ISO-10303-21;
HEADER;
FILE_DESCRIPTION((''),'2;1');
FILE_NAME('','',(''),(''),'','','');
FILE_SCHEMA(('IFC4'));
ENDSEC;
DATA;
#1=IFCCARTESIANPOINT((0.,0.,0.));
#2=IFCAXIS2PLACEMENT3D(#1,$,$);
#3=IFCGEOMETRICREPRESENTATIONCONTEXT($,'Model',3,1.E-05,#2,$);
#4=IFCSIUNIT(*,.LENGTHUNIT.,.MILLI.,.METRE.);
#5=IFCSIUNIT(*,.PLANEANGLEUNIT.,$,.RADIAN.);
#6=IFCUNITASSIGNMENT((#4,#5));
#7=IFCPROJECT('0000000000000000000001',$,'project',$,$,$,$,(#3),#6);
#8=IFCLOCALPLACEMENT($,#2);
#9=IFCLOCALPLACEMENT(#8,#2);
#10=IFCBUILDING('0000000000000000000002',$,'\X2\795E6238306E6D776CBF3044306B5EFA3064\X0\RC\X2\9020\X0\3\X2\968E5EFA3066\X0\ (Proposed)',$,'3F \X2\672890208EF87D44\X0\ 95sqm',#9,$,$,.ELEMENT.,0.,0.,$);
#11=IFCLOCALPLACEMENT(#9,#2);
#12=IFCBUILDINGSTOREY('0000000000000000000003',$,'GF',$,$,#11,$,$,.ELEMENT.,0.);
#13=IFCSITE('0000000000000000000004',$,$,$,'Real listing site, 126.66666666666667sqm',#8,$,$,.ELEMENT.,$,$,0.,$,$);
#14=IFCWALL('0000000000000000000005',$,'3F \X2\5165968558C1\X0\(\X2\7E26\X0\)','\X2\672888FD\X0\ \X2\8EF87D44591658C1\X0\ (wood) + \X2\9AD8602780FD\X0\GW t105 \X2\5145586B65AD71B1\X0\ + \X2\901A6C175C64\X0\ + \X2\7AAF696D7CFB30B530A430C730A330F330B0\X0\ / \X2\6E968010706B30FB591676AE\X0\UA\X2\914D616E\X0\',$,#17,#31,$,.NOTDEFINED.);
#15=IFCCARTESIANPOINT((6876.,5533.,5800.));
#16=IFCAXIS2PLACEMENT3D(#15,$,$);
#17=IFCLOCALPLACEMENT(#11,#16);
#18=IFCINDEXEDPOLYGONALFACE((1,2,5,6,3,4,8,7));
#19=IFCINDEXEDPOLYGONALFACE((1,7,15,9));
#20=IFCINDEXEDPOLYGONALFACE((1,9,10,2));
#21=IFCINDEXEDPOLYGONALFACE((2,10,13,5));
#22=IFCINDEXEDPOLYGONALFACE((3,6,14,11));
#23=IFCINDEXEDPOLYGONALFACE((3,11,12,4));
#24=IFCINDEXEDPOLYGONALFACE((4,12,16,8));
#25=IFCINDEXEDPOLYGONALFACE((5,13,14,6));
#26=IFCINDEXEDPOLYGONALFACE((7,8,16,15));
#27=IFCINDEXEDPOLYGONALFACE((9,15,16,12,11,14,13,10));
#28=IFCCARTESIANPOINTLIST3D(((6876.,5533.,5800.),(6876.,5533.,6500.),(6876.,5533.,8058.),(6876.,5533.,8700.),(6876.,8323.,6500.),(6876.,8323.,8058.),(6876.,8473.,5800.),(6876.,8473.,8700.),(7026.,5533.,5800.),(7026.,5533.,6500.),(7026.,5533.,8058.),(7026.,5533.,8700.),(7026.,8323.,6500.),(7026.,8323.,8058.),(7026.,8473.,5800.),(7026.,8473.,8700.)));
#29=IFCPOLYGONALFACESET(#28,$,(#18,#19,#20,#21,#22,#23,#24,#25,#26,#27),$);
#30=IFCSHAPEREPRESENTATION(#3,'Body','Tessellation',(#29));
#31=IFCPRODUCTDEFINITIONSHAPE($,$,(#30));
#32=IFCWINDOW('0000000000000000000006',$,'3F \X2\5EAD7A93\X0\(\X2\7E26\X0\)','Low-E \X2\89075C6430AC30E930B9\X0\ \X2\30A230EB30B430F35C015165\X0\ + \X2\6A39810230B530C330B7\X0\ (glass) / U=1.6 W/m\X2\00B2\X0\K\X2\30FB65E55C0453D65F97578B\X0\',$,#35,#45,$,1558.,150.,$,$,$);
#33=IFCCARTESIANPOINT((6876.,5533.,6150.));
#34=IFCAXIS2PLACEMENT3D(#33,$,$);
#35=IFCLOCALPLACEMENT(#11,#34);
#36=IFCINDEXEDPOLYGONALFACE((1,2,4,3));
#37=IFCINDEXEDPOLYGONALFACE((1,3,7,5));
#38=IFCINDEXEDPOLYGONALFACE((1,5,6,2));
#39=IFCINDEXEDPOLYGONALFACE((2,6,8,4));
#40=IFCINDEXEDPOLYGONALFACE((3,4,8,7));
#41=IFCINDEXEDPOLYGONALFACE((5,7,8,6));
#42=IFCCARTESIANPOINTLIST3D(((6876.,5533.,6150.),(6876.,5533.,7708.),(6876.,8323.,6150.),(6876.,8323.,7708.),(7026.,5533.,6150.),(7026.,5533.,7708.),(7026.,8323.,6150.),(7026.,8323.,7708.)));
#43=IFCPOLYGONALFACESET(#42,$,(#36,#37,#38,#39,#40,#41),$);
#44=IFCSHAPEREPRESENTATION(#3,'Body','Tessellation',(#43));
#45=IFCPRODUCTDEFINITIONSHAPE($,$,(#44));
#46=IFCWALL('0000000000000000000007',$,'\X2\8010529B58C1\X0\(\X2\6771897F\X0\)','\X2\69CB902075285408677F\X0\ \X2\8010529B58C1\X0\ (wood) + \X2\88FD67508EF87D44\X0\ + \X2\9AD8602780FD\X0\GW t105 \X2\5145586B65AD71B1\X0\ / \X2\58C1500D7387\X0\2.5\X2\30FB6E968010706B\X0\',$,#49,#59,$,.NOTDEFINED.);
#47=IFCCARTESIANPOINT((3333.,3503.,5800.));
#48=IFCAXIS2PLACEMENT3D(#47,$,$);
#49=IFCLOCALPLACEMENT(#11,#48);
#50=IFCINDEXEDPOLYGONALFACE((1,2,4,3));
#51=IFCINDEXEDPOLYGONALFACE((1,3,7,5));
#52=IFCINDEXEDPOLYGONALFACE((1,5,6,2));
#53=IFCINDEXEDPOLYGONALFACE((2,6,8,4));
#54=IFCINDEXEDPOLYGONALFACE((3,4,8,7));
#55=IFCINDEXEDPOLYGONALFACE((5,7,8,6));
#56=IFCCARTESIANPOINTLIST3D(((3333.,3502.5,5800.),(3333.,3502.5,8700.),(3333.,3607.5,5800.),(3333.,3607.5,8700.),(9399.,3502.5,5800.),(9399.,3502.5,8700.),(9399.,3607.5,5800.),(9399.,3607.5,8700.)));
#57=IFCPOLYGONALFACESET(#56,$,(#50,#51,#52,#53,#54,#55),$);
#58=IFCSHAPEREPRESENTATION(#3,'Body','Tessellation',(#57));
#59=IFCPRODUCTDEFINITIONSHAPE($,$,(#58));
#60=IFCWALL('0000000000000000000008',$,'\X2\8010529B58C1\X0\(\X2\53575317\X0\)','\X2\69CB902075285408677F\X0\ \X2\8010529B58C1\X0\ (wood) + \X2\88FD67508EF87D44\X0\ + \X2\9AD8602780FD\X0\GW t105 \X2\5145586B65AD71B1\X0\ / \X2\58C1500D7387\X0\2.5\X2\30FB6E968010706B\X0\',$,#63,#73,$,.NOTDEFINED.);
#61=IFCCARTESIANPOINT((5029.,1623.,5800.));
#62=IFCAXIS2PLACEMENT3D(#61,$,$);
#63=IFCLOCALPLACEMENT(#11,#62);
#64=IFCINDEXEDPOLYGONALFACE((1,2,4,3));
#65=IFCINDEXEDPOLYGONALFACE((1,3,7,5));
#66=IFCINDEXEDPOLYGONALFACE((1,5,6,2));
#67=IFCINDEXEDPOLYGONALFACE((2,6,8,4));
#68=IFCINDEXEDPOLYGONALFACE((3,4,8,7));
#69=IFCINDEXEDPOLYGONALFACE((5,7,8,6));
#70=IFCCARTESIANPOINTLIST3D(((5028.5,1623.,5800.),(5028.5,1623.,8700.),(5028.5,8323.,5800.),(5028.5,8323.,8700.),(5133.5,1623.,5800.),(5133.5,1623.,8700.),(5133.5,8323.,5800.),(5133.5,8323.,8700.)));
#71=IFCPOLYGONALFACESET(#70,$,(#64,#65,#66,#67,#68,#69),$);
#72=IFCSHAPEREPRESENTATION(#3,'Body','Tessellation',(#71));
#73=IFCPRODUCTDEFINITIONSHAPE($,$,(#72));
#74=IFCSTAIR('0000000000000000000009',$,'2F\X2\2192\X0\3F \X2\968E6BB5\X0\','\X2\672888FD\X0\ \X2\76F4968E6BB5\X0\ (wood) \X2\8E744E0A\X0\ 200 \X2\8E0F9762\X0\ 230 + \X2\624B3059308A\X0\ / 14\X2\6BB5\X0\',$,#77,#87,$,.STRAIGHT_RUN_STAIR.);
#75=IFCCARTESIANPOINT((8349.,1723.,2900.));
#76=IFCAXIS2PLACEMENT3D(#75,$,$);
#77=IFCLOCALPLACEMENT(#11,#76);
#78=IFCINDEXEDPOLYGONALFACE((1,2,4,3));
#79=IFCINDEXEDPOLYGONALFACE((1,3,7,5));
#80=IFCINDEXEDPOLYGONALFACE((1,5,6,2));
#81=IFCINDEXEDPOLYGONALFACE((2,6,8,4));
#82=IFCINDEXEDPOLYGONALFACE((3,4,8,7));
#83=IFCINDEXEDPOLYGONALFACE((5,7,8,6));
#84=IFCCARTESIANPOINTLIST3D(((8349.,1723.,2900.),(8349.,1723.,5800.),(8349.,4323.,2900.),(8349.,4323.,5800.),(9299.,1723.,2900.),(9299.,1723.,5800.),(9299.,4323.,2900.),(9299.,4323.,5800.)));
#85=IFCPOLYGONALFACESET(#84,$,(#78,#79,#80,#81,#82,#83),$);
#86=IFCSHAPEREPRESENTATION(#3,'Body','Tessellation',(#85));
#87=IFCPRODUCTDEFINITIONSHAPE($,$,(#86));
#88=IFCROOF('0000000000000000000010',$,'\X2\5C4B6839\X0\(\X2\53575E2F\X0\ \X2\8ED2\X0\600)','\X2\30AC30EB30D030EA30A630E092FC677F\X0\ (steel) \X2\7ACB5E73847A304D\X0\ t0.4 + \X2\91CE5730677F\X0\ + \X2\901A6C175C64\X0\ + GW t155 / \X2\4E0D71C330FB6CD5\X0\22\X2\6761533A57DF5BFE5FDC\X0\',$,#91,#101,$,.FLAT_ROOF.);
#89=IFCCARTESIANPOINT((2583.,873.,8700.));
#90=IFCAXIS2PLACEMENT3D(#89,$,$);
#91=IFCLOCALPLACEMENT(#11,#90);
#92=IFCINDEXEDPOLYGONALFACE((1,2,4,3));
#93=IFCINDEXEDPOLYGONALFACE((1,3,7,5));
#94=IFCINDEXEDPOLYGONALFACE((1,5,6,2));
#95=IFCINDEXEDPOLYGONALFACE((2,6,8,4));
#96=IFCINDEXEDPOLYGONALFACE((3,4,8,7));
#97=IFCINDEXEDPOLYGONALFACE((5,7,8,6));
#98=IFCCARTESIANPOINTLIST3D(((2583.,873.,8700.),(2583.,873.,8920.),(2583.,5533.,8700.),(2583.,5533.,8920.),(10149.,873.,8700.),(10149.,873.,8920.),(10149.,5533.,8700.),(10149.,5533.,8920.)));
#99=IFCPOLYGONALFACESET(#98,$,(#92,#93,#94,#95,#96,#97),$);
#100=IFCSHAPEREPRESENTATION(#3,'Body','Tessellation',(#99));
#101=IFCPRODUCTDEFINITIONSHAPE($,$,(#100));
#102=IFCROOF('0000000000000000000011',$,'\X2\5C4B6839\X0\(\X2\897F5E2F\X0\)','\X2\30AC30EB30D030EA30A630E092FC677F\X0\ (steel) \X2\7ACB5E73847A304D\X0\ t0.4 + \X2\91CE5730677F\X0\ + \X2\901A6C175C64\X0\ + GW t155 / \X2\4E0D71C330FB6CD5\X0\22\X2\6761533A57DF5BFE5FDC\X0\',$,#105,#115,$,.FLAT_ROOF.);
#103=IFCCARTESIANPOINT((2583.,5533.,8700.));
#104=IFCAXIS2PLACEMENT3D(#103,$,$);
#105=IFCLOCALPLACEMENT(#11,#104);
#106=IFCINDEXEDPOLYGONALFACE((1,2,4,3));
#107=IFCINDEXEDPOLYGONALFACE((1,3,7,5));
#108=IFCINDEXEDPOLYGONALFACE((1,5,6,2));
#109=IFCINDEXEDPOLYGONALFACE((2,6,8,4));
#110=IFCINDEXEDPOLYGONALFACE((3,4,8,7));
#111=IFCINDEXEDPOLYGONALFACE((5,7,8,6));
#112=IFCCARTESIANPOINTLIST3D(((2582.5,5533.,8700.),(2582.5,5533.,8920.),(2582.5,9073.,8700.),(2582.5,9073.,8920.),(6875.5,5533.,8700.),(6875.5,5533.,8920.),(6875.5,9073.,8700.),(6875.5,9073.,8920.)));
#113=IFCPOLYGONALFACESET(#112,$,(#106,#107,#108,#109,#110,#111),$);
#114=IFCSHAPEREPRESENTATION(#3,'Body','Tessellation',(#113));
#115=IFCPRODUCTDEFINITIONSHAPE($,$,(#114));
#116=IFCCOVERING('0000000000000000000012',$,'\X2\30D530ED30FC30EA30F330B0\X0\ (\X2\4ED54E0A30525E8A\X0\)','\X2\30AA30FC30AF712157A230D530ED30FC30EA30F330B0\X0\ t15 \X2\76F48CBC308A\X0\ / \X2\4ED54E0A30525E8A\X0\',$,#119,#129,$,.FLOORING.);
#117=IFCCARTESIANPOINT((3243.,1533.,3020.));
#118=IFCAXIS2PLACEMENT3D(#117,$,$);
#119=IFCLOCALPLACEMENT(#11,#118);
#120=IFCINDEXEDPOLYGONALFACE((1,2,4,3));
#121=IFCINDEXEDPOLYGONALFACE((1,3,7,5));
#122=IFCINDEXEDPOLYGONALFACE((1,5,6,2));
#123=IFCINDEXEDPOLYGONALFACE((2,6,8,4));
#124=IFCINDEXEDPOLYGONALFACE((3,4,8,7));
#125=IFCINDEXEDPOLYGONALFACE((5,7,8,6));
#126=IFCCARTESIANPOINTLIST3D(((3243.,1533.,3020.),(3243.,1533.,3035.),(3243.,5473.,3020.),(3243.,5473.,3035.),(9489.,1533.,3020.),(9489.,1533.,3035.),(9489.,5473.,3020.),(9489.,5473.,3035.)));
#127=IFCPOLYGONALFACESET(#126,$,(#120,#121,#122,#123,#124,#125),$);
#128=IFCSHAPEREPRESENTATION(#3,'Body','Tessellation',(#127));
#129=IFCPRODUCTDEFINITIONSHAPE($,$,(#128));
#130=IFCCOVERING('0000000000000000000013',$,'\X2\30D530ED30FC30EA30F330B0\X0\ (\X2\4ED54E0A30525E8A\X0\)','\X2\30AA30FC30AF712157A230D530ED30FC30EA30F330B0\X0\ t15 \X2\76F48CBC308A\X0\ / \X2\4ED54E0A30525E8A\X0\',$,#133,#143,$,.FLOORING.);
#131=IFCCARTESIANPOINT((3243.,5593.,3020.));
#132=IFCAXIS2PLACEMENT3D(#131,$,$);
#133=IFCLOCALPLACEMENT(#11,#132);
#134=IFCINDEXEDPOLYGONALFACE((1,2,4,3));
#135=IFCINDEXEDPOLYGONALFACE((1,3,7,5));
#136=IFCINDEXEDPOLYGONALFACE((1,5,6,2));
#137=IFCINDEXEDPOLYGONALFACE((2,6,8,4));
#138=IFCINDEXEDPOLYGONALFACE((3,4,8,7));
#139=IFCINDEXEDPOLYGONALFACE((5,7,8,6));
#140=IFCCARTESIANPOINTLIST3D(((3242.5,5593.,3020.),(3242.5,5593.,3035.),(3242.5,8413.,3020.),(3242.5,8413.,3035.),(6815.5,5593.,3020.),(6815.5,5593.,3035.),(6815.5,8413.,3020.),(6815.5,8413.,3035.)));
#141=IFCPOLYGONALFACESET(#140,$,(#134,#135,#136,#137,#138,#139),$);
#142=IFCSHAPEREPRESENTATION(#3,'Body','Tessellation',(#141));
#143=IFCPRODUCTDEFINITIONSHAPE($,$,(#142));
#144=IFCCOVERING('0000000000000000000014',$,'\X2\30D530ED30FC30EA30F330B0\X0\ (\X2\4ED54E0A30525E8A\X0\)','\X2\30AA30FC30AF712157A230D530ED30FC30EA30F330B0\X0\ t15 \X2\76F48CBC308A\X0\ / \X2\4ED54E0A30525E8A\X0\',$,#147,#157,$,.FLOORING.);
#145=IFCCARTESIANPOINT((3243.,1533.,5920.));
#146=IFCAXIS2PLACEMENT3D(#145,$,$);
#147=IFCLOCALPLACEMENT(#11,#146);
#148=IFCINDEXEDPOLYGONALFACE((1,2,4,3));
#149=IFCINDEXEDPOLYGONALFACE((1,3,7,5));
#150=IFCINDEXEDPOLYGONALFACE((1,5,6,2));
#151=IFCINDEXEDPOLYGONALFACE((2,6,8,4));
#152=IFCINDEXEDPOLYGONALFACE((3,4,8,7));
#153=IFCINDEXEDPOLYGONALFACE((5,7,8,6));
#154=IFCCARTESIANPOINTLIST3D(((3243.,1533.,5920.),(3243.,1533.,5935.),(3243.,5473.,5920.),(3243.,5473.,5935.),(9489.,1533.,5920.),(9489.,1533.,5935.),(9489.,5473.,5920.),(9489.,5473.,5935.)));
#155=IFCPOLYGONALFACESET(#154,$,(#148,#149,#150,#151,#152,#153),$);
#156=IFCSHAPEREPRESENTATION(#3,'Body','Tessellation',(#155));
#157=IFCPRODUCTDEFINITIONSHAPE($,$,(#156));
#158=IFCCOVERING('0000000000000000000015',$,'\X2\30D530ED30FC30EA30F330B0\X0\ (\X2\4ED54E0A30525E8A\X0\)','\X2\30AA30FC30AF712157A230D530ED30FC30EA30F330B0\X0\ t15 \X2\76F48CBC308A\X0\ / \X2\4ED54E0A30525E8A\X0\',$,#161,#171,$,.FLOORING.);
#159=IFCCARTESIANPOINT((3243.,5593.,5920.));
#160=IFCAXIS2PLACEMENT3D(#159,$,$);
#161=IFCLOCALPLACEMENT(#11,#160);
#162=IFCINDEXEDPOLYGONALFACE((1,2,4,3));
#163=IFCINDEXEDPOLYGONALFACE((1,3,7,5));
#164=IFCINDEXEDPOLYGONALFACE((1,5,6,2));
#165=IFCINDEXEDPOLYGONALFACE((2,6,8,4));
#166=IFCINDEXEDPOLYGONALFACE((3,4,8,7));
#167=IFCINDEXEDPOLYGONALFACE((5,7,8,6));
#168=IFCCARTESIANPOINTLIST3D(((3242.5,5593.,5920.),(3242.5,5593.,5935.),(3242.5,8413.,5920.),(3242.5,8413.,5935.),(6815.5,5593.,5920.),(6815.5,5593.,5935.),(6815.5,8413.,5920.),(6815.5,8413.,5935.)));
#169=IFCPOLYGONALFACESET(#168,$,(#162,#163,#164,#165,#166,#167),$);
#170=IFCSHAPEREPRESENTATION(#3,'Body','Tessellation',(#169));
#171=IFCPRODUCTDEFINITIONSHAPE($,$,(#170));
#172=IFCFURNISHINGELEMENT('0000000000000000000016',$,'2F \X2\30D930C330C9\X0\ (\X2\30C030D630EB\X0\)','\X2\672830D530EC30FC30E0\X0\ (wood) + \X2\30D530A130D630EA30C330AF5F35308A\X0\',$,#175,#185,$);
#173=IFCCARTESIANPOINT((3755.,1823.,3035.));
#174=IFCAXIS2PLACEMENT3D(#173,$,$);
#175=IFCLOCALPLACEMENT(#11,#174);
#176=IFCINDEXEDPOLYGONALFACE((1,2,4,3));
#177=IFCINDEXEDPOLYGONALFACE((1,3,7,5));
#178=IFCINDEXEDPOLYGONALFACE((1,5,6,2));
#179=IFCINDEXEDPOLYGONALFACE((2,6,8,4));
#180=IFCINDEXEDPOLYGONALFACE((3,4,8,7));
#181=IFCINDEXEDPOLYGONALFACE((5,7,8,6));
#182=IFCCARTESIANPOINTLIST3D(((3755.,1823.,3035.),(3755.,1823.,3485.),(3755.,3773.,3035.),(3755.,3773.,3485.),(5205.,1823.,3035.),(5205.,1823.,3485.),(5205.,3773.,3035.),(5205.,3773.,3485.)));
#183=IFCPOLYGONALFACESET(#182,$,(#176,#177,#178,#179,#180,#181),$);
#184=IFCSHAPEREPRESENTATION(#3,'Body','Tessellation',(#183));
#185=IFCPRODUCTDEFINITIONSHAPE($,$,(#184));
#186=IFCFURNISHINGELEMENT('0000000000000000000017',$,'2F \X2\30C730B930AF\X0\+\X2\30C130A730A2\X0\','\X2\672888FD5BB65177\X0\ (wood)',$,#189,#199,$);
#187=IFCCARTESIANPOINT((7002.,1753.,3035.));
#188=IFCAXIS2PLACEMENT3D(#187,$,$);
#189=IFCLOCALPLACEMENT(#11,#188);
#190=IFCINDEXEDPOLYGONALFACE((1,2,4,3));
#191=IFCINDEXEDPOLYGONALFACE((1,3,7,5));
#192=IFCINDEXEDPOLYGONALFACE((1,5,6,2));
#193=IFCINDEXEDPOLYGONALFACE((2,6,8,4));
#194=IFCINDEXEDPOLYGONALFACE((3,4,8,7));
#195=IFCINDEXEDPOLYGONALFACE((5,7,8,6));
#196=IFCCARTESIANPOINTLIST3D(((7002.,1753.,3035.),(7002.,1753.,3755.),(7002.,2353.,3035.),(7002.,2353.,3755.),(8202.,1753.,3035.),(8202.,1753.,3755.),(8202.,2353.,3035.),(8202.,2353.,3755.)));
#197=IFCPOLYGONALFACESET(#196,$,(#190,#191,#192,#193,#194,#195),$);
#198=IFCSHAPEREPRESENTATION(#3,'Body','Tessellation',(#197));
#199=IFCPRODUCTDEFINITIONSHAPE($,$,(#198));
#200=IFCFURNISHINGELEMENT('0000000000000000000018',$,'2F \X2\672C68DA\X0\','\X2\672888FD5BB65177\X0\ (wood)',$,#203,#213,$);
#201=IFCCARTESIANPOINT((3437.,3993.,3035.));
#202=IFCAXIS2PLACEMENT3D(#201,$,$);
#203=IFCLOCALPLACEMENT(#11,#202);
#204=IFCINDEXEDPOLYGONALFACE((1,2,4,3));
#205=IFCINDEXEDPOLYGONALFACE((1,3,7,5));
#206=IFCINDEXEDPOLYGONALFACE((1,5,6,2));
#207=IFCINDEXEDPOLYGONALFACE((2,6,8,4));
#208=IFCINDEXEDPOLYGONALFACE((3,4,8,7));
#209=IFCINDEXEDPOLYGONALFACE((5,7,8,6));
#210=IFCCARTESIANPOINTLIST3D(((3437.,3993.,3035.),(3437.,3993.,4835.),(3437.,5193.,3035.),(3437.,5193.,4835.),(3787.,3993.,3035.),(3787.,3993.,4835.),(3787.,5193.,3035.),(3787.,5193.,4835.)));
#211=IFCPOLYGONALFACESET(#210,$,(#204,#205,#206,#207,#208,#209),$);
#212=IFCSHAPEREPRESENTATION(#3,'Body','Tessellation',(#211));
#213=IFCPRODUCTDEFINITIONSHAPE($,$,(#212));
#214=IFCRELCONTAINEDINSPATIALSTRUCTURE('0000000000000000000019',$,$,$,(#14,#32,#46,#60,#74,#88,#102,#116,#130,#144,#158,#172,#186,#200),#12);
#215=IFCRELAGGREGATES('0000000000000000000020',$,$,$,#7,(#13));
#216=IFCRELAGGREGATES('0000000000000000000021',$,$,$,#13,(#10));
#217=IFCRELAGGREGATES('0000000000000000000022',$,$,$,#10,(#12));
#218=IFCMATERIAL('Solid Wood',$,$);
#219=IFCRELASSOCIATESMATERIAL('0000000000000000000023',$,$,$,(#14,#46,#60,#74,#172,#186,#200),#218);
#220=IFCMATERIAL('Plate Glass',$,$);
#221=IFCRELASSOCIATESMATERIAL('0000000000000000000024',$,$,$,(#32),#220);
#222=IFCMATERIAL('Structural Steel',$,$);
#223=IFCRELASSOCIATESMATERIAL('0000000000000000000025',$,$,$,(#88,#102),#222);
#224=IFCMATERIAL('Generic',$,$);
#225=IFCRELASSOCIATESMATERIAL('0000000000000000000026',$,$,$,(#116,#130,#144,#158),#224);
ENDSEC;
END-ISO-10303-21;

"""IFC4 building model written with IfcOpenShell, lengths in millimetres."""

from ifc_helpers import new_model, si_unit, frame, frame_2d, origin, place, context, project, spatial, rectangle, extrude, material, element, fill, save


model = new_model("IFC4")

# Units and contexts
model_context = context("Model", 3, precision=1e-05, world=origin())
ifc_project = project(units=[si_unit("LENGTHUNIT", "METRE", prefix="MILLI"), si_unit("PLANEANGLEUNIT", "RADIAN")], contexts=[model_context])

# Site, building, storey
site_placement = place(None, origin())
site = spatial("IfcSite", under=ifc_project, at=site_placement, ObjectType="Real listing site, 126.66666666666667sqm", CompositionType="ELEMENT", RefElevation=0.0)
building_placement = place(site_placement, origin())
building = spatial("IfcBuilding", under=site, at=building_placement, Name="神戸の海沿いに建つRC造3階建て (Proposed)", ObjectType="3F 木造軸組 95sqm", CompositionType="ELEMENT", ElevationOfRefHeight=0.0, ElevationOfTerrain=0.0)
storey_placement = place(building_placement, origin())
storey = spatial("IfcBuildingStorey", under=building, at=storey_placement, Name="GF", CompositionType="ELEMENT", Elevation=0.0)

# Shared definitions
ifc_material_1 = material(Name="Solid Wood")

# Shared definitions
ifc_material_2 = material(Name="Plate Glass")

# Wall, opening, window
wall_1_placement = place(storey_placement, frame((6876.0, 5533.0, 5800.0)))
wall_1 = element("IfcWall", 1, at=wall_1_placement, inside=storey, material=ifc_material_1, Name="3F 入隅壁(縦)", Description="木製 軸組外壁 (wood) + 高性能GW t105 充填断熱 + 通気層 + 窯業系サイディング / 準耐火・外皮UA配慮", PredefinedType="NOTDEFINED", context=model_context, shape_type="SweptSolid", body=[
    extrude(rectangle(XDim=150.0, YDim=2940.0, at=frame_2d((75.0, 1470.0))), frame((6876.0, 5533.0, 5800.0)), (0.0, 0.0, 1.0), 2900.0),
])
opening_1_placement = place(storey_placement, frame((6876.0, 5533.0, 6150.0)))
opening_1 = element("IfcOpeningElement", 2, at=opening_1_placement, cuts=wall_1, PredefinedType="NOTDEFINED", context=model_context, shape_type="SweptSolid", body=[
    extrude(rectangle(XDim=150.0, YDim=2790.0, at=frame_2d((75.0, 1395.0))), frame((6876.0, 5533.0, 6150.0)), (0.0, 0.0, 1.0), 1558.0),
])
window_1_placement = place(storey_placement, frame((6876.0, 5533.0, 6150.0)))
window_1 = element("IfcWindow", 3, at=window_1_placement, inside=storey, material=ifc_material_2, Name="3F 庭窓(縦)", Description="Low-E 複層ガラス アルゴン封入 + 樹脂サッシ (glass) / U=1.6 W/m²K・日射取得型", OverallHeight=1558.0, OverallWidth=150.0, context=model_context, shape_type="SweptSolid", body=[
    extrude(rectangle(XDim=150.0, YDim=2790.0, at=frame_2d((75.0, 1395.0))), frame((6876.0, 5533.0, 6150.0)), (0.0, 0.0, 1.0), 1558.0),
])
fill(opening_1, window_1)

# Walls
wall_2_placement = place(storey_placement, frame((3333.0, 3503.0, 5800.0)))
element("IfcWall", 4, at=wall_2_placement, inside=storey, material=ifc_material_1, Name="耐力壁(東西)", Description="構造用合板 耐力壁 (wood) + 製材軸組 + 高性能GW t105 充填断熱 / 壁倍率2.5・準耐火", PredefinedType="NOTDEFINED", context=model_context, shape_type="SweptSolid", body=[
    extrude(rectangle(XDim=6066.0, YDim=105.0, at=frame_2d((3033.0, 52.0))), frame((3333.0, 3503.0, 5800.0)), (0.0, 0.0, 1.0), 2900.0),
])
wall_3_placement = place(storey_placement, frame((5029.0, 1623.0, 5800.0)))
element("IfcWall", 5, at=wall_3_placement, inside=storey, material=ifc_material_1, Name="耐力壁(南北)", Description="構造用合板 耐力壁 (wood) + 製材軸組 + 高性能GW t105 充填断熱 / 壁倍率2.5・準耐火", PredefinedType="NOTDEFINED", context=model_context, shape_type="SweptSolid", body=[
    extrude(rectangle(XDim=105.0, YDim=6700.0, at=frame_2d((52.0, 3350.0))), frame((5029.0, 1623.0, 5800.0)), (0.0, 0.0, 1.0), 2900.0),
])

# Stair
stair_placement = place(storey_placement, frame((8349.0, 1723.0, 2900.0)))
element("IfcStair", 6, at=stair_placement, inside=storey, material=ifc_material_1, Name="2F→3F 階段", Description="木製 直階段 (wood) 蹴上 200 踏面 230 + 手すり / 14段", PredefinedType="STRAIGHT_RUN_STAIR", context=model_context, shape_type="SweptSolid", body=[
    extrude(rectangle(XDim=950.0, YDim=2600.0, at=frame_2d((475.0, 1300.0))), frame((8349.0, 1723.0, 2900.0)), (0.0, 0.0, 1.0), 2900.0),
])

# Roofs
ifc_material_3 = material(Name="Structural Steel")
roof_1_placement = place(storey_placement, frame((2583.0, 873.0, 8700.0)))
element("IfcRoof", 7, at=roof_1_placement, inside=storey, material=ifc_material_3, Name="屋根(南帯 軒600)", Description="ガルバリウム鋼板 (steel) 立平葺き t0.4 + 野地板 + 通気層 + GW t155 / 不燃・法22条区域対応", PredefinedType="FLAT_ROOF", context=model_context, shape_type="SweptSolid", body=[
    extrude(rectangle(XDim=7566.0, YDim=4660.0, at=frame_2d((3783.0, 2330.0))), frame((2583.0, 873.0, 8700.0)), (0.0, 0.0, 1.0), 220.0),
])
roof_2_placement = place(storey_placement, frame((2583.0, 5533.0, 8700.0)))
element("IfcRoof", 8, at=roof_2_placement, inside=storey, material=ifc_material_3, Name="屋根(西帯)", Description="ガルバリウム鋼板 (steel) 立平葺き t0.4 + 野地板 + 通気層 + GW t155 / 不燃・法22条区域対応", PredefinedType="FLAT_ROOF", context=model_context, shape_type="SweptSolid", body=[
    extrude(rectangle(XDim=4293.0, YDim=3540.0, at=frame_2d((2146.0, 1770.0))), frame((2583.0, 5533.0, 8700.0)), (0.0, 0.0, 1.0), 220.0),
])

# Coverings
ifc_material_4 = material(Name="Generic")
covering_1_placement = place(storey_placement, frame((3243.0, 1533.0, 3020.0)))
element("IfcCovering", 9, at=covering_1_placement, inside=storey, material=ifc_material_4, Name="フローリング (仕上げ床)", Description="オーク無垢フローリング t15 直貼り / 仕上げ床", PredefinedType="FLOORING", context=model_context, shape_type="SweptSolid", body=[
    extrude(rectangle(XDim=6246.0, YDim=3940.0, at=frame_2d((3123.0, 1970.0))), frame((3243.0, 1533.0, 3020.0)), (0.0, 0.0, 1.0), 15.0),
])
covering_2_placement = place(storey_placement, frame((3243.0, 5593.0, 3020.0)))
element("IfcCovering", 10, at=covering_2_placement, inside=storey, material=ifc_material_4, Name="フローリング (仕上げ床)", Description="オーク無垢フローリング t15 直貼り / 仕上げ床", PredefinedType="FLOORING", context=model_context, shape_type="SweptSolid", body=[
    extrude(rectangle(XDim=3573.0, YDim=2820.0, at=frame_2d((1786.0, 1410.0))), frame((3243.0, 5593.0, 3020.0)), (0.0, 0.0, 1.0), 15.0),
])
covering_3_placement = place(storey_placement, frame((3243.0, 1533.0, 5920.0)))
element("IfcCovering", 11, at=covering_3_placement, inside=storey, material=ifc_material_4, Name="フローリング (仕上げ床)", Description="オーク無垢フローリング t15 直貼り / 仕上げ床", PredefinedType="FLOORING", context=model_context, shape_type="SweptSolid", body=[
    extrude(rectangle(XDim=6246.0, YDim=3940.0, at=frame_2d((3123.0, 1970.0))), frame((3243.0, 1533.0, 5920.0)), (0.0, 0.0, 1.0), 15.0),
])
covering_4_placement = place(storey_placement, frame((3243.0, 5593.0, 5920.0)))
element("IfcCovering", 12, at=covering_4_placement, inside=storey, material=ifc_material_4, Name="フローリング (仕上げ床)", Description="オーク無垢フローリング t15 直貼り / 仕上げ床", PredefinedType="FLOORING", context=model_context, shape_type="SweptSolid", body=[
    extrude(rectangle(XDim=3573.0, YDim=2820.0, at=frame_2d((1786.0, 1410.0))), frame((3243.0, 5593.0, 5920.0)), (0.0, 0.0, 1.0), 15.0),
])

# Furnishing elements
furnishing_1_placement = place(storey_placement, frame((3755.0, 1823.0, 3035.0)))
element("IfcFurnishingElement", 13, at=furnishing_1_placement, inside=storey, material=ifc_material_1, Name="2F ベッド (ダブル)", Description="木フレーム (wood) + ファブリック張り", context=model_context, shape_type="SweptSolid", body=[
    extrude(rectangle(XDim=1450.0, YDim=1950.0, at=frame_2d((725.0, 975.0))), frame((3755.0, 1823.0, 3035.0)), (0.0, 0.0, 1.0), 450.0),
])
furnishing_2_placement = place(storey_placement, frame((7002.0, 1753.0, 3035.0)))
element("IfcFurnishingElement", 14, at=furnishing_2_placement, inside=storey, material=ifc_material_1, Name="2F デスク+チェア", Description="木製家具 (wood)", context=model_context, shape_type="SweptSolid", body=[
    extrude(rectangle(XDim=1200.0, YDim=600.0, at=frame_2d((600.0, 300.0))), frame((7002.0, 1753.0, 3035.0)), (0.0, 0.0, 1.0), 720.0),
])
furnishing_3_placement = place(storey_placement, frame((3437.0, 3993.0, 3035.0)))
element("IfcFurnishingElement", 15, at=furnishing_3_placement, inside=storey, material=ifc_material_1, Name="2F 本棚", Description="木製家具 (wood)", context=model_context, shape_type="SweptSolid", body=[
    extrude(rectangle(XDim=350.0, YDim=1200.0, at=frame_2d((175.0, 600.0))), frame((3437.0, 3993.0, 3035.0)), (0.0, 0.0, 1.0), 1800.0),
])

save(model, "model.ifc")
